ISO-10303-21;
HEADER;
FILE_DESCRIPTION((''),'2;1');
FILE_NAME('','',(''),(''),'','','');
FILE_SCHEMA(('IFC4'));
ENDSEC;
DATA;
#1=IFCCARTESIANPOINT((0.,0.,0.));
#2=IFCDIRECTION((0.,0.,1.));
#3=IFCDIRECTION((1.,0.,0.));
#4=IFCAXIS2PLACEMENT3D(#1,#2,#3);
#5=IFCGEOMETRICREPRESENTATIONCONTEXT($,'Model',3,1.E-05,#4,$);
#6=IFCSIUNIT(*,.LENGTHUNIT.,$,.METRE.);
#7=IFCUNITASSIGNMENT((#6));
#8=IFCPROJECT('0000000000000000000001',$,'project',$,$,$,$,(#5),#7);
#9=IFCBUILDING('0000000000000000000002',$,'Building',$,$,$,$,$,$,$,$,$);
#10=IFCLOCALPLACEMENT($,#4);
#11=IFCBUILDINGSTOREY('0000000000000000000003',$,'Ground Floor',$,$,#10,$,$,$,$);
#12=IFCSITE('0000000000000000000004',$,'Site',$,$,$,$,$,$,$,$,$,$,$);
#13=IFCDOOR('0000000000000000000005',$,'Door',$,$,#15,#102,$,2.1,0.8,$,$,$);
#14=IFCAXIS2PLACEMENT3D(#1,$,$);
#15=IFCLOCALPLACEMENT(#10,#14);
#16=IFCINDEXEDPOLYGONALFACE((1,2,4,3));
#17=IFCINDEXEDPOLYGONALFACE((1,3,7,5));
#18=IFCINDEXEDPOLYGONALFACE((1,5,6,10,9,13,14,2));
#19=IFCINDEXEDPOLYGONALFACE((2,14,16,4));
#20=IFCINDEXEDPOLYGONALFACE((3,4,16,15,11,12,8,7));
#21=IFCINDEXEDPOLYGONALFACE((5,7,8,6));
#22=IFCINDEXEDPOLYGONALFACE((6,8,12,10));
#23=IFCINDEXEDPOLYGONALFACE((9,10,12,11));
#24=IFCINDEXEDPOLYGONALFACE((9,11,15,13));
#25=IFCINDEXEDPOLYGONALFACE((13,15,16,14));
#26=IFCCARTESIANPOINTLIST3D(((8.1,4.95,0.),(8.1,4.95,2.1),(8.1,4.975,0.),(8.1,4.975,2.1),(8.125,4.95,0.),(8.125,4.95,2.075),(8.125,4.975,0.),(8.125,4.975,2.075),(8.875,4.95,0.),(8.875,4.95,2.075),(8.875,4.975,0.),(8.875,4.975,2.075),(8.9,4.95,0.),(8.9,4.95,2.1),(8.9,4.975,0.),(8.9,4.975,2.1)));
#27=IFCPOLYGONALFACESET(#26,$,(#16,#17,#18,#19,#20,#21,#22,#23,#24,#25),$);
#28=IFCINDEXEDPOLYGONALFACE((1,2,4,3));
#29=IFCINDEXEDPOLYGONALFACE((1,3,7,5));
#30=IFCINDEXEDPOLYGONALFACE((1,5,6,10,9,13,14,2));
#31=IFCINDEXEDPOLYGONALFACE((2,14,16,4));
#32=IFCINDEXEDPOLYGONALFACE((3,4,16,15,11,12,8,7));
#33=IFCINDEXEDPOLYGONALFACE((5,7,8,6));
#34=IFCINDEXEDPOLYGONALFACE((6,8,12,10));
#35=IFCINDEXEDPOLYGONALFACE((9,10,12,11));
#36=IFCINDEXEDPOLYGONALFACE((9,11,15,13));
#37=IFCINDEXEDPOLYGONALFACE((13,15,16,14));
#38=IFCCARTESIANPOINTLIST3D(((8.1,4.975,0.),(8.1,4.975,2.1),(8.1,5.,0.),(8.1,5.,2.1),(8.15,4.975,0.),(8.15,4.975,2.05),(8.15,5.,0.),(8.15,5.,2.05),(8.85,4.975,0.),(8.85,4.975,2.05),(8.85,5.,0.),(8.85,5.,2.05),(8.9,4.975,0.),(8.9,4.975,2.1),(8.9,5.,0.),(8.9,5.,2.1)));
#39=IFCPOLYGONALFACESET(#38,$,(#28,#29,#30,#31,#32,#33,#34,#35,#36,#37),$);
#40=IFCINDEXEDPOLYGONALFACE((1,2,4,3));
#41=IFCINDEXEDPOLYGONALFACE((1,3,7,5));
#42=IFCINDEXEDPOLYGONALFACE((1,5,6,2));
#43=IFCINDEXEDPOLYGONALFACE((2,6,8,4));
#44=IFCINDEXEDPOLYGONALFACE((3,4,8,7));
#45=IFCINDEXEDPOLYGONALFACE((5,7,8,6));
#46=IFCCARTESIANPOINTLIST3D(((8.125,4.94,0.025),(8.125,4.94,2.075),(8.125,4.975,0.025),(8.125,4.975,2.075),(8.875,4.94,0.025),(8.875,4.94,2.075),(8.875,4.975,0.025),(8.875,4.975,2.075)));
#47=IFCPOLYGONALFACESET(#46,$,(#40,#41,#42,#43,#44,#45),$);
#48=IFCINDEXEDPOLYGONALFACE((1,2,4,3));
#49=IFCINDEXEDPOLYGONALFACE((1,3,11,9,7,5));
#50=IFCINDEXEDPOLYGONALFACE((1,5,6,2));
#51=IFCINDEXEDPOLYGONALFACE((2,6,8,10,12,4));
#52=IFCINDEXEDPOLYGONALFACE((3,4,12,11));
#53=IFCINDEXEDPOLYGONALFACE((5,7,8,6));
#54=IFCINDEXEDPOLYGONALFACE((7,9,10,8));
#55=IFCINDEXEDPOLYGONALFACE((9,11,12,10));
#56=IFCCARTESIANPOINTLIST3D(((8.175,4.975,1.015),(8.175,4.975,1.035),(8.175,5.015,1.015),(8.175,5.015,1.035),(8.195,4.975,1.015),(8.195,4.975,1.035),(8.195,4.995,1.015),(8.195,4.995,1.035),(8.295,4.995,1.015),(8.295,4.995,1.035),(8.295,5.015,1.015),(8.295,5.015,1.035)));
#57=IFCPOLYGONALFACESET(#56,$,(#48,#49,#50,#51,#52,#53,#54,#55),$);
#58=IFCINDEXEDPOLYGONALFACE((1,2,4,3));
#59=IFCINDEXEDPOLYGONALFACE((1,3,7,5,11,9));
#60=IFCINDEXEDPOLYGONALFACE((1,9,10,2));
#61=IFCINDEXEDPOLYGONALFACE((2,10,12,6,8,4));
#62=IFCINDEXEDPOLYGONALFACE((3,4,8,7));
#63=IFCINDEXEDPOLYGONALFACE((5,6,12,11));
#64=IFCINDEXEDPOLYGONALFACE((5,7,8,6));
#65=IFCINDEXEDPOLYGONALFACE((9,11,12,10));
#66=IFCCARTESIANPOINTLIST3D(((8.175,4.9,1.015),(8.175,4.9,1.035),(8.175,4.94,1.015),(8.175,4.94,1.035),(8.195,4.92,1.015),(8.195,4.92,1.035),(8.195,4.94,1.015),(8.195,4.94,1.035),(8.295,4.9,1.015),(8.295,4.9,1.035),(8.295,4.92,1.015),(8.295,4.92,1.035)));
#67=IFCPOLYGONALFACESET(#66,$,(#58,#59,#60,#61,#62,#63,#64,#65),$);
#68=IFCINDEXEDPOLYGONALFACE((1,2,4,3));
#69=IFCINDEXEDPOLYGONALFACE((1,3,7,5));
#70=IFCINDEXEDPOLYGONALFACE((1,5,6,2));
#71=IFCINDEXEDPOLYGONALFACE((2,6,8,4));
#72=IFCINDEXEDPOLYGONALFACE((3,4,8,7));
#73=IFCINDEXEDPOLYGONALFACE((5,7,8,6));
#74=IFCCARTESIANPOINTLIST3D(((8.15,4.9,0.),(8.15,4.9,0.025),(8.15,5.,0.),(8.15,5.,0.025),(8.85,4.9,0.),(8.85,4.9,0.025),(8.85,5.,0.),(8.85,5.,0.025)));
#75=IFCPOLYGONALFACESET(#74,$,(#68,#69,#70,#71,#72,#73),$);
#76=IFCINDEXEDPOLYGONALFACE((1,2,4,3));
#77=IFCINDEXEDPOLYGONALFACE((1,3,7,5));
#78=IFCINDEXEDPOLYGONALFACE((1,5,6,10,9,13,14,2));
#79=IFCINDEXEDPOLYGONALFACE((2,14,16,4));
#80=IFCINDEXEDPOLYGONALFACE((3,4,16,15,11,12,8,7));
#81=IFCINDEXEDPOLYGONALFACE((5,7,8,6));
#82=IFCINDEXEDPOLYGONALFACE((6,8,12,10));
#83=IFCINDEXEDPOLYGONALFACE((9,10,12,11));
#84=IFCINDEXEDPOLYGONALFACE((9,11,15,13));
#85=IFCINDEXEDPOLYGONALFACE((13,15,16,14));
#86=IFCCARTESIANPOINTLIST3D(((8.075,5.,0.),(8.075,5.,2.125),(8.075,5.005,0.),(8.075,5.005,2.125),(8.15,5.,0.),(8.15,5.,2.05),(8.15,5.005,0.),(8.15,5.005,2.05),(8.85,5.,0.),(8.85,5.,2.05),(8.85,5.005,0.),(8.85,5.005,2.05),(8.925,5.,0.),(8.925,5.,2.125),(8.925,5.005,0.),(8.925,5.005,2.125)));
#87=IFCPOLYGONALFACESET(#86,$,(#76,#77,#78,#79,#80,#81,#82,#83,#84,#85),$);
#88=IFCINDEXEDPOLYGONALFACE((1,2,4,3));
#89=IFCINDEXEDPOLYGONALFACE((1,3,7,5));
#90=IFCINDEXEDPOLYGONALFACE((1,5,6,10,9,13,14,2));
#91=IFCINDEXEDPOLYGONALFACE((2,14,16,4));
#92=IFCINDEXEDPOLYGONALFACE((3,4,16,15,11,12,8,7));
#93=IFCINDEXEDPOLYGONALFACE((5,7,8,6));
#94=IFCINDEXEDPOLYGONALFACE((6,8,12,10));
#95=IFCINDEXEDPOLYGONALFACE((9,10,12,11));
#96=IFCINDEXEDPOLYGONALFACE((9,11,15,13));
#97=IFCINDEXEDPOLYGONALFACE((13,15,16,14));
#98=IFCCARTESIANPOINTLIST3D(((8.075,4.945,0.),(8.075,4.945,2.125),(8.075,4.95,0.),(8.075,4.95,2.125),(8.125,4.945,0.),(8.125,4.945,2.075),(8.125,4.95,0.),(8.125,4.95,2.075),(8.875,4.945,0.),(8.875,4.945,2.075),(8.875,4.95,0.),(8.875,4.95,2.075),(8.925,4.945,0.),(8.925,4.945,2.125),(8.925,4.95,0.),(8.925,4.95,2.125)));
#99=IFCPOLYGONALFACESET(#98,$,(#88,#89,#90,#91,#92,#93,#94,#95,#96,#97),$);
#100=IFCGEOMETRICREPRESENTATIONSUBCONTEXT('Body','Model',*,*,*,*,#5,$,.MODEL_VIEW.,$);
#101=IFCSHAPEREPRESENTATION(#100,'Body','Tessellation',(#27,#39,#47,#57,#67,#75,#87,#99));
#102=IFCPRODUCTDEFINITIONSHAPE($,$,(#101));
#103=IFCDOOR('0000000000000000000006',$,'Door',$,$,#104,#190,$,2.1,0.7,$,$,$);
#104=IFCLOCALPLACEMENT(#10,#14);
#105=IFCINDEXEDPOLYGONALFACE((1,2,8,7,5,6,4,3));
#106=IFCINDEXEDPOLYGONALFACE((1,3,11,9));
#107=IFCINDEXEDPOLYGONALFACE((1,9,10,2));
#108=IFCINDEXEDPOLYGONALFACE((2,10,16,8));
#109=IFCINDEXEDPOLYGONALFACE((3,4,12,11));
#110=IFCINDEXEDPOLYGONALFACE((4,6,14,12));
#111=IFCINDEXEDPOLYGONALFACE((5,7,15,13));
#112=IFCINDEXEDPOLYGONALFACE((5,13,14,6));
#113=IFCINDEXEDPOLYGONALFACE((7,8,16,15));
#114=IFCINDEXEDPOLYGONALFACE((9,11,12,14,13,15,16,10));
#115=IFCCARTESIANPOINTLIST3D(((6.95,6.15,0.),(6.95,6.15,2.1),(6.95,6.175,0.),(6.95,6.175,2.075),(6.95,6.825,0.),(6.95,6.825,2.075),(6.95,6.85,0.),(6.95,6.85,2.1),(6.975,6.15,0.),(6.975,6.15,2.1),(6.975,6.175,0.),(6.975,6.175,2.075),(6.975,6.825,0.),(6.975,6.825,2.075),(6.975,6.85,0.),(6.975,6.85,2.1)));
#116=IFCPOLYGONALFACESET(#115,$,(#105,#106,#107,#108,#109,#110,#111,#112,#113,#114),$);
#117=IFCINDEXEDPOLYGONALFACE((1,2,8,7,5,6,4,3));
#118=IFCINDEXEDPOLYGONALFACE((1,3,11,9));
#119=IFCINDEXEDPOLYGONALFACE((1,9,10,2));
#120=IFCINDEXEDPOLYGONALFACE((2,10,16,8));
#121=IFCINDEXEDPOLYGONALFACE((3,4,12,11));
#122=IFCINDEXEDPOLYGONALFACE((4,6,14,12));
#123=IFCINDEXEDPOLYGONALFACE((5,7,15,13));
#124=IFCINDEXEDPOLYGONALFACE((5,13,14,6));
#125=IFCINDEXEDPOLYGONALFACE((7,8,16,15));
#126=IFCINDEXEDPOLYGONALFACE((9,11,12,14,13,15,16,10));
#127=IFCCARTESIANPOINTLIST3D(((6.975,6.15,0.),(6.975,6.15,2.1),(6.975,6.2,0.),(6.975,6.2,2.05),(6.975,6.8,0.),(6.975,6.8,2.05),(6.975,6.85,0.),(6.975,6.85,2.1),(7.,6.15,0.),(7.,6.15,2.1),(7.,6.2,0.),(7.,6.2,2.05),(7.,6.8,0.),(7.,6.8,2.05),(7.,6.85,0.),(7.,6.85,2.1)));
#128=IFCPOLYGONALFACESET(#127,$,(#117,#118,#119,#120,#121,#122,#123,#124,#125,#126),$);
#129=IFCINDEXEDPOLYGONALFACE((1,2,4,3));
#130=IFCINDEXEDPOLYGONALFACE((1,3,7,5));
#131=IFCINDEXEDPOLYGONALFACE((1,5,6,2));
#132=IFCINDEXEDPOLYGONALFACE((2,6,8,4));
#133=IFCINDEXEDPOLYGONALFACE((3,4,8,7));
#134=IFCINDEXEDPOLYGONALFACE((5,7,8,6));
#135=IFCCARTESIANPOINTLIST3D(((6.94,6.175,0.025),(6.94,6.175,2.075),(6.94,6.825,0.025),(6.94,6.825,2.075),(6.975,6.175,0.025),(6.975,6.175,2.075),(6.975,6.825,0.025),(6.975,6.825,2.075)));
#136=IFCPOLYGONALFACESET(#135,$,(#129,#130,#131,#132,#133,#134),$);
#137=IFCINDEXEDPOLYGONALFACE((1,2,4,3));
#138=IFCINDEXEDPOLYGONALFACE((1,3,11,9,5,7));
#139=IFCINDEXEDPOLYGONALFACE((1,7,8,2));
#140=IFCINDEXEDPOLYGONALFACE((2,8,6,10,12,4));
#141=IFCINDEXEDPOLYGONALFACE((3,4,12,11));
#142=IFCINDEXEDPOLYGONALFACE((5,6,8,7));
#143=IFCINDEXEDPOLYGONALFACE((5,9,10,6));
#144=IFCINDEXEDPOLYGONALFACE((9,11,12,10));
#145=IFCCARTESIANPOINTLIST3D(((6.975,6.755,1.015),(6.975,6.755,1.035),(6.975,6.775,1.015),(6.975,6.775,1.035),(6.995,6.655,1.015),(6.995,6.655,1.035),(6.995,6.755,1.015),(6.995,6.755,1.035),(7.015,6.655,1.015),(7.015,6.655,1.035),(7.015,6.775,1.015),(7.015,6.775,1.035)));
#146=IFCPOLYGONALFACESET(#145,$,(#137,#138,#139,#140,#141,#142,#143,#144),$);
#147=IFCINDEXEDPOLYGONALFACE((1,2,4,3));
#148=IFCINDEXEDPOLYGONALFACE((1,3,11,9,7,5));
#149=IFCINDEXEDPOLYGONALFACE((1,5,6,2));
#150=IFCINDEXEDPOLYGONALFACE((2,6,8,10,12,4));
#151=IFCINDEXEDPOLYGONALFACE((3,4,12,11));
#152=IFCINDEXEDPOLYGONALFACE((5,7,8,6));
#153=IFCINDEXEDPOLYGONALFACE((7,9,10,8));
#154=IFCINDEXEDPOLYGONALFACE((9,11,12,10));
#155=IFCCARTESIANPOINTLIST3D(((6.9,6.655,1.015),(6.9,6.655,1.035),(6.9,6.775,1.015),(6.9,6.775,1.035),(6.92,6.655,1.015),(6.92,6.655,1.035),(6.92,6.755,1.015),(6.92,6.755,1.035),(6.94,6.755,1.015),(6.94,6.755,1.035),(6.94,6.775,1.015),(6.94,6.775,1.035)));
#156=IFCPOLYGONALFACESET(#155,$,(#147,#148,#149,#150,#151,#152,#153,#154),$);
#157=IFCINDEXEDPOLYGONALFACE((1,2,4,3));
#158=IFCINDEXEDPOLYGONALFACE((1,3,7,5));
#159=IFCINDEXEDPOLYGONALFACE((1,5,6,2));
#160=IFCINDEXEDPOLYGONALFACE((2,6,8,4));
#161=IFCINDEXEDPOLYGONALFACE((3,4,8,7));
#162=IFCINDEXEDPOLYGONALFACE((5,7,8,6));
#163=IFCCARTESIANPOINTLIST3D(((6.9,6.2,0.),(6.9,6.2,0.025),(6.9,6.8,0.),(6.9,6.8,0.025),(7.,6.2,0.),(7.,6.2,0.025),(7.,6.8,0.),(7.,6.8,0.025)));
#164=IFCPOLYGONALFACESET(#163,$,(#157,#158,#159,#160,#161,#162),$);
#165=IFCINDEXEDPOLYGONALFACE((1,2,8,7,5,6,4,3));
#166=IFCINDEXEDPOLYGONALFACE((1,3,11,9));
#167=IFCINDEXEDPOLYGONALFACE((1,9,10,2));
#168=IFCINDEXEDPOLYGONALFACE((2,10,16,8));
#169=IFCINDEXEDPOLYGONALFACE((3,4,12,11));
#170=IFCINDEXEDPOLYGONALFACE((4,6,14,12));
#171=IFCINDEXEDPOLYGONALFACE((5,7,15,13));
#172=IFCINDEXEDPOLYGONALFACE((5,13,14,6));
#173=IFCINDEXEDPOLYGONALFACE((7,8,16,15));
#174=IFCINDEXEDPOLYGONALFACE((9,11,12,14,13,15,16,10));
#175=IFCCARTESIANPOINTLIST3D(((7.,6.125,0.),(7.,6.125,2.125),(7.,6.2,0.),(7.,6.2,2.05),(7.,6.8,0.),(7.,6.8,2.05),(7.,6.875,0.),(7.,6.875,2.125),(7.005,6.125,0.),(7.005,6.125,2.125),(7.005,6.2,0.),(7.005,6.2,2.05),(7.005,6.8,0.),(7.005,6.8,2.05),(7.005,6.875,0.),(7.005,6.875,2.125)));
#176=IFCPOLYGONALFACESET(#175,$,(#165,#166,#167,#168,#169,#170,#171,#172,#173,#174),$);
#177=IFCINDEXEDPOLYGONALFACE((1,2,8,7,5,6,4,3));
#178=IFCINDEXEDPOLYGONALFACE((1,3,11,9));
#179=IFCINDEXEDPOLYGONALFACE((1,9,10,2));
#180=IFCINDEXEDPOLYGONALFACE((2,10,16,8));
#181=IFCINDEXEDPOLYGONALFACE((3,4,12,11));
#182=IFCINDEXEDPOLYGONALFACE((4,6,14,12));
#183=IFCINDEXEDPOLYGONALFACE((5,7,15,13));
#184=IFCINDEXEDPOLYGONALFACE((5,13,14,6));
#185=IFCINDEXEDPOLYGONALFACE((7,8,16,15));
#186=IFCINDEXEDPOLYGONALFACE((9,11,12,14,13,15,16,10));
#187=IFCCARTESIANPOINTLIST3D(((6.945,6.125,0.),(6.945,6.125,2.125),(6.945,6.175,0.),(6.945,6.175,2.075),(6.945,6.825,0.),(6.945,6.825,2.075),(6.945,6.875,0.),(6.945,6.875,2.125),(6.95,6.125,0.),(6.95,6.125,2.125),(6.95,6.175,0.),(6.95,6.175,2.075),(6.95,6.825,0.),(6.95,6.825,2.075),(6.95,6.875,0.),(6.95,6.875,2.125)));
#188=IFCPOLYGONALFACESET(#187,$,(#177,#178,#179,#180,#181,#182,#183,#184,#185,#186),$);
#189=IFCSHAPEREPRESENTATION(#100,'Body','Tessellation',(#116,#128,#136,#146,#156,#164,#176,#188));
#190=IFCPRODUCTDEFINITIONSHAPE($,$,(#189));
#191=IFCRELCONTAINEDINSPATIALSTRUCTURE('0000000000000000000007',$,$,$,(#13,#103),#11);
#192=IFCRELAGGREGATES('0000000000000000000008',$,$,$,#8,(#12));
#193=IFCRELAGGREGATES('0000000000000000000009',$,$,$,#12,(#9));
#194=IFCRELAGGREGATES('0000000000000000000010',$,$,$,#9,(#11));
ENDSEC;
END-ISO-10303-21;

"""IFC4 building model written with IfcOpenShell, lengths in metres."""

from ifc_helpers import new_model, si_unit, frame, origin_with_axes, place, context, subcontext, project, spatial, line, indexed_curve, outline, extrude, element, save


model = new_model("IFC4")

# Units and contexts
model_context = context("Model", 3, precision=1e-05, world=origin_with_axes())
body_context = subcontext(model_context, "Body", "Model", "MODEL_VIEW")
ifc_project = project(units=[si_unit("LENGTHUNIT", "METRE")], contexts=[model_context])

# Site, building, storey
site = spatial("IfcSite", under=ifc_project, Name="Site")
building = spatial("IfcBuilding", under=site, Name="Building")
storey_placement = place(None, origin_with_axes())
storey = spatial("IfcBuildingStorey", under=building, at=storey_placement, Name="Ground Floor")

# Doors
door_1_placement = place(storey_placement, frame((8.9, 5.0, 0.0), z_axis=(0.0, 0.0, 1.0), x_axis=(-1.0, 0.0, 0.0)))
element("IfcDoor", 1, at=door_1_placement, inside=storey, Name="Door", OverallHeight=2.1, OverallWidth=0.8, context=body_context, shape_type="SweptSolid", body=[
    extrude(outline(indexed_curve([(0.0, 0.0), (0.0, 2.1), (0.8, 2.1), (0.8, 0.0), (0.775, 0.0), (0.775, 2.075), (0.025, 2.075), (0.025, 0.0)], segments=[line(1, 2, 3, 4, 5, 6, 7, 8, 1)])), frame((0.0, 0.025, 0.0), z_axis=(0.0, -1.0, 0.0), x_axis=(1.0, 0.0, 0.0)), (0.0, 0.0, -1.0), 0.025),
    extrude(outline(indexed_curve([(0.0, 0.0), (0.0, 2.1), (0.8, 2.1), (0.8, 0.0), (0.75, 0.0), (0.75, 2.05), (0.05, 2.05), (0.05, 0.0)], segments=[line(1, 2, 3, 4, 5, 6, 7, 8, 1)])), frame((0.0, 0.0, 0.0), z_axis=(0.0, -1.0, 0.0), x_axis=(1.0, 0.0, 0.0)), (0.0, 0.0, -1.0), 0.025),
    extrude(outline(indexed_curve([(0.0, 0.0), (0.75, 0.0), (0.75, 0.035), (0.0, 0.035)], segments=[line(1, 2, 3, 4, 1)])), frame((0.025, 0.025, 0.025), z_axis=(0.0, 0.0, 1.0), x_axis=(1.0, 0.0, 0.0)), (0.0, 0.0, 1.0), 2.05),
    extrude(outline(indexed_curve([(0.0, 0.0), (0.0, -0.04), (-0.12, -0.04), (-0.12, -0.02), (-0.02, -0.02), (-0.02, 0.0)], segments=[line(1, 2, 3, 4, 5, 6, 1)])), frame((0.725, 0.025, 1.015), z_axis=(0.0, 0.0, 1.0), x_axis=(1.0, 0.0, 0.0)), (0.0, 0.0, 1.0), 0.02),
    extrude(outline(indexed_curve([(0.0, 0.0), (0.0, 0.04), (-0.12, 0.04), (-0.12, 0.02), (-0.02, 0.02), (-0.02, 0.0)], segments=[line(1, 2, 3, 4, 5, 6, 1)])), frame((0.725, 0.06, 1.015), z_axis=(0.0, 0.0, 1.0), x_axis=(1.0, 0.0, 0.0)), (0.0, 0.0, 1.0), 0.02),
    extrude(outline(indexed_curve([(0.0, 0.0), (0.7, 0.0), (0.7, 0.1), (0.0, 0.1)], segments=[line(1, 2, 3, 4, 1)])), frame((0.05, 0.0, 0.0), z_axis=(0.0, 0.0, 1.0), x_axis=(1.0, 0.0, 0.0)), (0.0, 0.0, 1.0), 0.025),
    extrude(outline(indexed_curve([(0.0, 0.0), (0.0, 2.125), (0.85, 2.125), (0.85, 0.0), (0.775, 0.0), (0.775, 2.05), (0.075, 2.05), (0.075, 0.0)], segments=[line(1, 2, 3, 4, 5, 6, 7, 8, 1)])), frame((-0.025, -0.005, 0.0), z_axis=(0.0, -1.0, 0.0), x_axis=(1.0, 0.0, 0.0)), (0.0, 0.0, -1.0), 0.005),
    extrude(outline(indexed_curve([(0.0, 0.0), (0.0, 2.125), (0.85, 2.125), (0.85, 0.0), (0.8, 0.0), (0.8, 2.075), (0.05, 2.075), (0.05, 0.0)], segments=[line(1, 2, 3, 4, 5, 6, 7, 8, 1)])), frame((-0.025, 0.05, 0.0), z_axis=(0.0, -1.0, 0.0), x_axis=(1.0, 0.0, 0.0)), (0.0, 0.0, -1.0), 0.005),
])
door_2_placement = place(storey_placement, frame((7.0, 6.15, 0.0), z_axis=(0.0, 0.0, 1.0), x_axis=(0.0, 1.0, 0.0)))
element("IfcDoor", 2, at=door_2_placement, inside=storey, Name="Door", OverallHeight=2.1, OverallWidth=0.7, context=body_context, shape_type="SweptSolid", body=[
    extrude(outline(indexed_curve([(0.0, 0.0), (0.0, 2.1), (0.7, 2.1), (0.7, 0.0), (0.675, 0.0), (0.675, 2.075), (0.025, 2.075), (0.025, 0.0)], segments=[line(1, 2, 3, 4, 5, 6, 7, 8, 1)])), frame((0.0, 0.025, 0.0), z_axis=(0.0, -1.0, 0.0), x_axis=(1.0, 0.0, 0.0)), (0.0, 0.0, -1.0), 0.025),
    extrude(outline(indexed_curve([(0.0, 0.0), (0.0, 2.1), (0.7, 2.1), (0.7, 0.0), (0.65, 0.0), (0.65, 2.05), (0.05, 2.05), (0.05, 0.0)], segments=[line(1, 2, 3, 4, 5, 6, 7, 8, 1)])), frame((0.0, 0.0, 0.0), z_axis=(0.0, -1.0, 0.0), x_axis=(1.0, 0.0, 0.0)), (0.0, 0.0, -1.0), 0.025),
    extrude(outline(indexed_curve([(0.0, 0.0), (0.65, 0.0), (0.65, 0.035), (0.0, 0.035)], segments=[line(1, 2, 3, 4, 1)])), frame((0.025, 0.025, 0.025), z_axis=(0.0, 0.0, 1.0), x_axis=(1.0, 0.0, 0.0)), (0.0, 0.0, 1.0), 2.05),
    extrude(outline(indexed_curve([(0.0, 0.0), (0.0, -0.04), (-0.12, -0.04), (-0.12, -0.02), (-0.02, -0.02), (-0.02, 0.0)], segments=[line(1, 2, 3, 4, 5, 6, 1)])), frame((0.625, 0.025, 1.015), z_axis=(0.0, 0.0, 1.0), x_axis=(1.0, 0.0, 0.0)), (0.0, 0.0, 1.0), 0.02),
    extrude(outline(indexed_curve([(0.0, 0.0), (0.0, 0.04), (-0.12, 0.04), (-0.12, 0.02), (-0.02, 0.02), (-0.02, 0.0)], segments=[line(1, 2, 3, 4, 5, 6, 1)])), frame((0.625, 0.06, 1.015), z_axis=(0.0, 0.0, 1.0), x_axis=(1.0, 0.0, 0.0)), (0.0, 0.0, 1.0), 0.02),
    extrude(outline(indexed_curve([(0.0, 0.0), (0.6, 0.0), (0.6, 0.1), (0.0, 0.1)], segments=[line(1, 2, 3, 4, 1)])), frame((0.05, 0.0, 0.0), z_axis=(0.0, 0.0, 1.0), x_axis=(1.0, 0.0, 0.0)), (0.0, 0.0, 1.0), 0.025),
    extrude(outline(indexed_curve([(0.0, 0.0), (0.0, 2.125), (0.75, 2.125), (0.75, 0.0), (0.675, 0.0), (0.675, 2.05), (0.075, 2.05), (0.075, 0.0)], segments=[line(1, 2, 3, 4, 5, 6, 7, 8, 1)])), frame((-0.025, -0.005, 0.0), z_axis=(0.0, -1.0, 0.0), x_axis=(1.0, 0.0, 0.0)), (0.0, 0.0, -1.0), 0.005),
    extrude(outline(indexed_curve([(0.0, 0.0), (0.0, 2.125), (0.75, 2.125), (0.75, 0.0), (0.7, 0.0), (0.7, 2.075), (0.05, 2.075), (0.05, 0.0)], segments=[line(1, 2, 3, 4, 5, 6, 7, 8, 1)])), frame((-0.025, 0.05, 0.0), z_axis=(0.0, -1.0, 0.0), x_axis=(1.0, 0.0, 0.0)), (0.0, 0.0, -1.0), 0.005),
])

save(model, "model.ifc")
